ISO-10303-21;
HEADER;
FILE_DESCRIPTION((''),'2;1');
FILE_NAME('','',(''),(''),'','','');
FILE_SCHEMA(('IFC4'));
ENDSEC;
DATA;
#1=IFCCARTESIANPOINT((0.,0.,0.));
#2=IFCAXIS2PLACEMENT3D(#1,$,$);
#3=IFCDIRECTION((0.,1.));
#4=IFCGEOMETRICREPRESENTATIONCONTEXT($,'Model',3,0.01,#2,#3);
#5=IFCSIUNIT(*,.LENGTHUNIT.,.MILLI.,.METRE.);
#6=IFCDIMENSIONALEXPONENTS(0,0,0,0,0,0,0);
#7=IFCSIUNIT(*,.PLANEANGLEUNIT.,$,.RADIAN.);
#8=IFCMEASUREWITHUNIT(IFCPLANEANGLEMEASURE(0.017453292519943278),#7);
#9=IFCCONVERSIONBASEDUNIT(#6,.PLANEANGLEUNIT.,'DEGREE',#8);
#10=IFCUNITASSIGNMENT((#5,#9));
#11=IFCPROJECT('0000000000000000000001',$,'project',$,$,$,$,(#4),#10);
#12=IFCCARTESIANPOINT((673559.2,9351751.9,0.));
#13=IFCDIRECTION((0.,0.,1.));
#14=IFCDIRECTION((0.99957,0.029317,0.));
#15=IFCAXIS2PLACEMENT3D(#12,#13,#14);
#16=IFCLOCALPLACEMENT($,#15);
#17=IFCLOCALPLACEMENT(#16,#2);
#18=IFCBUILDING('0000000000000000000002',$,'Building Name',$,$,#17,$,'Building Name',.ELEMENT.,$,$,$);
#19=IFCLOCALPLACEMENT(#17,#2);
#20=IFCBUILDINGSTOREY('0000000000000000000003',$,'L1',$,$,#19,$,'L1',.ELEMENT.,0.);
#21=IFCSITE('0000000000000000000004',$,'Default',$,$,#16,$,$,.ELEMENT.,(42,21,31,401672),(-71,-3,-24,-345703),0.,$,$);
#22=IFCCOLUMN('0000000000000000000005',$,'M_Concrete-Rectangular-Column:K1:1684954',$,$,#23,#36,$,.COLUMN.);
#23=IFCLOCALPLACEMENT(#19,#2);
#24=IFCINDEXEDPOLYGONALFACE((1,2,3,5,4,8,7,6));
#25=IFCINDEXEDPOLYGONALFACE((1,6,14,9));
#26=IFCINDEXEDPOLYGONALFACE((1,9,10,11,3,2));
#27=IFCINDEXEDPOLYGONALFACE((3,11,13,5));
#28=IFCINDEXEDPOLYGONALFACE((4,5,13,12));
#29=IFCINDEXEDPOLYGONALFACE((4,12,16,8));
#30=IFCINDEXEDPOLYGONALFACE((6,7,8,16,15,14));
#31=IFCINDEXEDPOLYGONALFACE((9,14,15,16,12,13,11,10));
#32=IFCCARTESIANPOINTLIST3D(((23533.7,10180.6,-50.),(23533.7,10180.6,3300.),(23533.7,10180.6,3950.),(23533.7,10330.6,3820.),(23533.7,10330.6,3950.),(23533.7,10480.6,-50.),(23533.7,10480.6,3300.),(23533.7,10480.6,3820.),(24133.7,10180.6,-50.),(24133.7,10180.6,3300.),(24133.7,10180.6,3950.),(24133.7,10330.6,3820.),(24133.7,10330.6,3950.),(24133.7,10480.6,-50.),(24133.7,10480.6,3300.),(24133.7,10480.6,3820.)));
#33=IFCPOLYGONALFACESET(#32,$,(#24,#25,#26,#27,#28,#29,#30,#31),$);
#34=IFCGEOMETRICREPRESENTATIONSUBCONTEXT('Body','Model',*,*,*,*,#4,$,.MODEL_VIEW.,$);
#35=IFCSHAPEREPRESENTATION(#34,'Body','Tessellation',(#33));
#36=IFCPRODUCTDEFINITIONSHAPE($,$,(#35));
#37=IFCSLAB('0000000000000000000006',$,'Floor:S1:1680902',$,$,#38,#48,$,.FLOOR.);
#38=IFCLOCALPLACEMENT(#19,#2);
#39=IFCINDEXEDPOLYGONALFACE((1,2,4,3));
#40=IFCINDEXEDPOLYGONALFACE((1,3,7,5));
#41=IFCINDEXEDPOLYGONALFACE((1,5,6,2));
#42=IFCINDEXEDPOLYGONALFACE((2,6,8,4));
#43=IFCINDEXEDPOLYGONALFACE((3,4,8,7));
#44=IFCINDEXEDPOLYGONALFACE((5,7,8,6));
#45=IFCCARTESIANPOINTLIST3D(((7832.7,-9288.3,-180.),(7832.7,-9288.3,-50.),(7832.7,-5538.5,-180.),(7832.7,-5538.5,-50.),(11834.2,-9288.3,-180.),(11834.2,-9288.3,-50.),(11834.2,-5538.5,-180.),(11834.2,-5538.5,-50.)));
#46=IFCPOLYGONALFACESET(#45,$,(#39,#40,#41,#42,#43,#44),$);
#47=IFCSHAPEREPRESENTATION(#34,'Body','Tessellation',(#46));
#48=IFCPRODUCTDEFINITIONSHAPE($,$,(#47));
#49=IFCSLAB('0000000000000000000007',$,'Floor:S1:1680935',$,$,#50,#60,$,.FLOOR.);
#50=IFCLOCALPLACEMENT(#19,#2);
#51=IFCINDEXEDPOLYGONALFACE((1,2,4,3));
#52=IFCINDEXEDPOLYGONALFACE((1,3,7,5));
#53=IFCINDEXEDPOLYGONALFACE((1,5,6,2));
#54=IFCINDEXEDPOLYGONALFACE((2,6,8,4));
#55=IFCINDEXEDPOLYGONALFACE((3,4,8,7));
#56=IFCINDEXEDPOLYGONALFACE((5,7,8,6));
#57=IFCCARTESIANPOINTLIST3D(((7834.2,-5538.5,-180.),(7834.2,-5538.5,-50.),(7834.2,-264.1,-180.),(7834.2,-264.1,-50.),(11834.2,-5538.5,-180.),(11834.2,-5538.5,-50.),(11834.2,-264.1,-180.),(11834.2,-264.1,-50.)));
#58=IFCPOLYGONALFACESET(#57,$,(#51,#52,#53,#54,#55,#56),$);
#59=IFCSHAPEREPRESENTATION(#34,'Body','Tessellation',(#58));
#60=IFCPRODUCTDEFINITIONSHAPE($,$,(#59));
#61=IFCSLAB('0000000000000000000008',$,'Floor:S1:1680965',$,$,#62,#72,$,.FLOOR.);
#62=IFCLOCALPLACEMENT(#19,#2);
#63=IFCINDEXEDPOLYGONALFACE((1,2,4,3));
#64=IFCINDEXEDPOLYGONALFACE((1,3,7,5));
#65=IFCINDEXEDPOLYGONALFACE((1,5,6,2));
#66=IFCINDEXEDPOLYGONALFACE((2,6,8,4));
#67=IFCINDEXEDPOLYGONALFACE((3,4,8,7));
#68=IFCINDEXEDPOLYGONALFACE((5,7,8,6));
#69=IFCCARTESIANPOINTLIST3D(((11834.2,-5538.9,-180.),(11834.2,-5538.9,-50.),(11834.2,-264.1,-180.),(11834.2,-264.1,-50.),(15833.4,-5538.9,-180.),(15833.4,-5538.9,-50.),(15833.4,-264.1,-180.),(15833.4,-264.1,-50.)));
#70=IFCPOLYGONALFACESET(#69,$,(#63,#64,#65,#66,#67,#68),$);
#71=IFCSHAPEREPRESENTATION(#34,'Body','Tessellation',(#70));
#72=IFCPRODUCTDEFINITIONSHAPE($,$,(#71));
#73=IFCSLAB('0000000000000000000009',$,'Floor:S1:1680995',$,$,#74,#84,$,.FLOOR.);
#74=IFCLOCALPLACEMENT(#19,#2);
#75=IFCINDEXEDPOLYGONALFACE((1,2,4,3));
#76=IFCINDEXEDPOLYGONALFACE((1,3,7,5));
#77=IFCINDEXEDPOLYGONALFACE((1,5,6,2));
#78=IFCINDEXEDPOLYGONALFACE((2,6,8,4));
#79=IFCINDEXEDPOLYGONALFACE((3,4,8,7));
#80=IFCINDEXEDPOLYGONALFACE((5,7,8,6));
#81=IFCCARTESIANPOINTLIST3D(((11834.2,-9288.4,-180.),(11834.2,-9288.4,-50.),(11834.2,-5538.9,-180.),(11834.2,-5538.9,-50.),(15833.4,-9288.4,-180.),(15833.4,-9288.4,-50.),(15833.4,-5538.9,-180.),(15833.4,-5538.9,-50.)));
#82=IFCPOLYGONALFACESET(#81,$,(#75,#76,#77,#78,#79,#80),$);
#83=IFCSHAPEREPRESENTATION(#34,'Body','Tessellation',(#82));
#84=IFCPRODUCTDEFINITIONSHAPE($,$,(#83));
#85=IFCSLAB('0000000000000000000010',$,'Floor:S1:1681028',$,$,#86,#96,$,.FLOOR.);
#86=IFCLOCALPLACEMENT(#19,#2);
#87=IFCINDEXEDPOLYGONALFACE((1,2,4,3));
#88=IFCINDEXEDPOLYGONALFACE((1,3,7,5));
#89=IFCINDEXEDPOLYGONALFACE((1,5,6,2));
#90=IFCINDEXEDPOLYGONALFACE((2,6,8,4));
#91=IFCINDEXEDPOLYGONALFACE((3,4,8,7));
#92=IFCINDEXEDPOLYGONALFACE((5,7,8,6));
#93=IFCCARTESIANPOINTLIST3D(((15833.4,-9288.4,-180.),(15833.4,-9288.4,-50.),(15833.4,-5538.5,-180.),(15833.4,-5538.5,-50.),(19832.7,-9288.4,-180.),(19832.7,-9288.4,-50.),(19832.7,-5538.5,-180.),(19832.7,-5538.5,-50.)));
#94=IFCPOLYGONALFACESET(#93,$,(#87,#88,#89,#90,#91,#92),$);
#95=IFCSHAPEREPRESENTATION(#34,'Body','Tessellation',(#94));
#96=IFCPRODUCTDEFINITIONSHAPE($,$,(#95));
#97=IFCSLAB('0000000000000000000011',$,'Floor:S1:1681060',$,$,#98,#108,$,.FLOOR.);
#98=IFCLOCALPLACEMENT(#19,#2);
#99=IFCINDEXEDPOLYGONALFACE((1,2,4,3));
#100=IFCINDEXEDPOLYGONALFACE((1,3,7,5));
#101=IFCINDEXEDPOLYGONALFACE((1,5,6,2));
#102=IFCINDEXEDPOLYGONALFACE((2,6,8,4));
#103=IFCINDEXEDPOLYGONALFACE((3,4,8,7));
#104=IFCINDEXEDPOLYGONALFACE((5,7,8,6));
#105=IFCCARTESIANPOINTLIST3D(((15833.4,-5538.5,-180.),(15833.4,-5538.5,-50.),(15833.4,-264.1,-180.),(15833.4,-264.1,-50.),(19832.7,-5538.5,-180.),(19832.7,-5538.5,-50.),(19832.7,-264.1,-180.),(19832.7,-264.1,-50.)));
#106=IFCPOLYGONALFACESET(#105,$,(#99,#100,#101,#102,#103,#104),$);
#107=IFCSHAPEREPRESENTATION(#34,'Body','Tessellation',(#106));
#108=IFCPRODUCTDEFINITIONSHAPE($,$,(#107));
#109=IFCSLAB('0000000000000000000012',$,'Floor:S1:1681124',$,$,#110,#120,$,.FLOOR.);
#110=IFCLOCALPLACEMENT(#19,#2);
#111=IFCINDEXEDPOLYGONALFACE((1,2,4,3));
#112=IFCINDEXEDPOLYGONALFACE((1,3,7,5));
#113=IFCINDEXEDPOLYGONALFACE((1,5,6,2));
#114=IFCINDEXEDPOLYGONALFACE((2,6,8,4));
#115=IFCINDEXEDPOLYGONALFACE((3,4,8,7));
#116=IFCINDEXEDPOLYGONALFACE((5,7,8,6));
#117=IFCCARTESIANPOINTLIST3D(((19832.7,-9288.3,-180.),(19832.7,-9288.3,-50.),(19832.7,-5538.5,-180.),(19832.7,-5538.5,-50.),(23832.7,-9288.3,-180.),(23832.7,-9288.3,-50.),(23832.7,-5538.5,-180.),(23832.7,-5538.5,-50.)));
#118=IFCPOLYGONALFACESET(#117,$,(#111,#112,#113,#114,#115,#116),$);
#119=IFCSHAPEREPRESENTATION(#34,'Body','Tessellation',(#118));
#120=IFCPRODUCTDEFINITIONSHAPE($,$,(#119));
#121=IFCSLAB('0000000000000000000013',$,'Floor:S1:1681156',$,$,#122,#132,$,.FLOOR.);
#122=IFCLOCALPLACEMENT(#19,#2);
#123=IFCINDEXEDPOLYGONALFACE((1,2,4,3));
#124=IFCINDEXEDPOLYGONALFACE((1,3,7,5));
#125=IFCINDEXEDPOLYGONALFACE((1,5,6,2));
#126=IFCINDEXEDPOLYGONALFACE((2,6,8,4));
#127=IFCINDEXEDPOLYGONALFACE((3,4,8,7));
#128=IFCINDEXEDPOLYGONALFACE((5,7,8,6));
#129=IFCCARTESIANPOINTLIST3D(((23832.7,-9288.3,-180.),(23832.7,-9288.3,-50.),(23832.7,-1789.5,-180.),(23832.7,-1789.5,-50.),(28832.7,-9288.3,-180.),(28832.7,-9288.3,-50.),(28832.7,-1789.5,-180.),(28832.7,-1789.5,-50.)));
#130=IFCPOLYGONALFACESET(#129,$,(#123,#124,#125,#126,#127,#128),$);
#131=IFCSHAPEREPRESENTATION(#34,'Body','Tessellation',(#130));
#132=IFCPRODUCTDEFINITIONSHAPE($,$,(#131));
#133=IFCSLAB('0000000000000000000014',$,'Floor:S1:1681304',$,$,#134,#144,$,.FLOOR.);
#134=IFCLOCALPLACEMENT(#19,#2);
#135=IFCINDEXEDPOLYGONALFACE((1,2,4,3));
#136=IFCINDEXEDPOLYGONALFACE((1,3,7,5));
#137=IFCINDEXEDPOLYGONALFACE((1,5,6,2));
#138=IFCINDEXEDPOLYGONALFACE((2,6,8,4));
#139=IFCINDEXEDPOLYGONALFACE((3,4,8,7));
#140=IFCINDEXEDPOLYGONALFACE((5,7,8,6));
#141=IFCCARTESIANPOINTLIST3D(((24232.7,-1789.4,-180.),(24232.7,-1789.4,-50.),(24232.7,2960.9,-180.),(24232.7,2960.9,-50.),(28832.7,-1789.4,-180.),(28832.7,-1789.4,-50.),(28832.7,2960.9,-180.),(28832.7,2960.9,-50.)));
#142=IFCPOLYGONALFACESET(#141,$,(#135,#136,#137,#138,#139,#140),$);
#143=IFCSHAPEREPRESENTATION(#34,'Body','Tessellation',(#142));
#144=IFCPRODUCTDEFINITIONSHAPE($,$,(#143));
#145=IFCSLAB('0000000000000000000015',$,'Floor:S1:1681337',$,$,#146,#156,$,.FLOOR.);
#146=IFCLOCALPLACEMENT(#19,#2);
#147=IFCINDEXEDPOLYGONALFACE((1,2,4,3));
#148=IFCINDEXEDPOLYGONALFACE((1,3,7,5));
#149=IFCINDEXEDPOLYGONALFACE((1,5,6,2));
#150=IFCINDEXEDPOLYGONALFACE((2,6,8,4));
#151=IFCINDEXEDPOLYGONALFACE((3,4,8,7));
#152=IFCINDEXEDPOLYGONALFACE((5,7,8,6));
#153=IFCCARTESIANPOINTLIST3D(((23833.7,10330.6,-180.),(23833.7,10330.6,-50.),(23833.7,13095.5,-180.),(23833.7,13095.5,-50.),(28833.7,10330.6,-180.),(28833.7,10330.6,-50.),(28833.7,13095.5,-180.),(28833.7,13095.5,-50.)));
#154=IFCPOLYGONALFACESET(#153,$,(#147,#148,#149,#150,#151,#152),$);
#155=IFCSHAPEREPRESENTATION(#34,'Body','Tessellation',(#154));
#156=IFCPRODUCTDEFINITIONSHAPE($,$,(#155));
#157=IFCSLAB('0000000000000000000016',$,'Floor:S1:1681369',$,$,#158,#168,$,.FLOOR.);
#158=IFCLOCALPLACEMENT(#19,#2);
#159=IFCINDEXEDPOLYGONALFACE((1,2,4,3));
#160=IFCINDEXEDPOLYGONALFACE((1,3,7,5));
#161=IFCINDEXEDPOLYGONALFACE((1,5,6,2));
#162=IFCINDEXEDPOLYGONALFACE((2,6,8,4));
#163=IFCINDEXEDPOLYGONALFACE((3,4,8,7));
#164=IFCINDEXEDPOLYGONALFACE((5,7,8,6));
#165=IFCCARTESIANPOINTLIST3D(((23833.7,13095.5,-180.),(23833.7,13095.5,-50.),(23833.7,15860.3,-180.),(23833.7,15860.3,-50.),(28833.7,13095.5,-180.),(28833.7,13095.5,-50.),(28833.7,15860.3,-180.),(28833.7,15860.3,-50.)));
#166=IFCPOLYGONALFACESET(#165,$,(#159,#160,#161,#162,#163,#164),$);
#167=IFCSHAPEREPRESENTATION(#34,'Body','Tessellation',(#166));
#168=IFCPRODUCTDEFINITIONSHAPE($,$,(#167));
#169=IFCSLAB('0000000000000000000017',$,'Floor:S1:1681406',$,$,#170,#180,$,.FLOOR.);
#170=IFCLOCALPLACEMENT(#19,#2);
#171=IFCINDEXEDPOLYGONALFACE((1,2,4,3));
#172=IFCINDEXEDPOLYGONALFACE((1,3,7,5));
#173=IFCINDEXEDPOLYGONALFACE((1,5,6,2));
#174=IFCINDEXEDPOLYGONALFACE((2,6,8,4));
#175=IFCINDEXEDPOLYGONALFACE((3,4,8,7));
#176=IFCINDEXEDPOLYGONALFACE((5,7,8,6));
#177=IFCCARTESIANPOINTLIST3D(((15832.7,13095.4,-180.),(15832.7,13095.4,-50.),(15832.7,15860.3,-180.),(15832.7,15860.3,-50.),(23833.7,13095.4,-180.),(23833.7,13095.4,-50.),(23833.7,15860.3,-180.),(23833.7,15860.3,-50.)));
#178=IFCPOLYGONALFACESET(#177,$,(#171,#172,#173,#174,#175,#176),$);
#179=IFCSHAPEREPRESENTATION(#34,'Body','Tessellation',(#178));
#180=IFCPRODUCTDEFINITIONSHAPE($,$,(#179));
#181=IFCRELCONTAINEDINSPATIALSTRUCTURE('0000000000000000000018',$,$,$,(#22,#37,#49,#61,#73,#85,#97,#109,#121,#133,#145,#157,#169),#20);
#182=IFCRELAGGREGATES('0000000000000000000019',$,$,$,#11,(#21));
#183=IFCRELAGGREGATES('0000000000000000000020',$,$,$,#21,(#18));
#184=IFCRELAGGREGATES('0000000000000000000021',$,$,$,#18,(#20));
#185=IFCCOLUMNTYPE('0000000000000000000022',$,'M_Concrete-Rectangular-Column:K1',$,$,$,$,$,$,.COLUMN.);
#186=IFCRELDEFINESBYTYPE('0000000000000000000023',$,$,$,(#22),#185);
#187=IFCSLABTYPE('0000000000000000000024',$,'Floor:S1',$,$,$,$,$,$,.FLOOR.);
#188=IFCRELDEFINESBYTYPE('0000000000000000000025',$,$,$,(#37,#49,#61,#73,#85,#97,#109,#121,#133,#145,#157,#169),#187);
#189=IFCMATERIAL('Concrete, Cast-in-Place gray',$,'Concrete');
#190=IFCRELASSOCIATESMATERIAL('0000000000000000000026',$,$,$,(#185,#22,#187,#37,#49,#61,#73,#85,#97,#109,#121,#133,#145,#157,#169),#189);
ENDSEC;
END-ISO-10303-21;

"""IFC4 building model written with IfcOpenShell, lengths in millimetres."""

from ifc_helpers import new_model, entity, si_unit, converted_unit, direction, frame, origin, place, context, subcontext, project, spatial, indexed_curve, outline, extrude, source, transform, mapped, material, type_object, type_shapes, element, save


model = new_model("IFC4")

# Units and contexts
model_context = context("Model", 3, precision=0.01, world=origin(), true_north=direction((0.0, 1.0)))
body_context = subcontext(model_context, "Body", "Model", "MODEL_VIEW")
ifc_project = project(units=[si_unit("LENGTHUNIT", "METRE", prefix="MILLI"), converted_unit("PLANEANGLEUNIT", "DEGREE", entity("IfcPlaneAngleMeasure", 0.017453292519943278), si_unit("PLANEANGLEUNIT", "RADIAN"), dimensions=[0, 0, 0, 0, 0, 0, 0])], contexts=[model_context])

# Site, building, storey
site_placement = place(None, frame((673559.2, 9351751.9, 0.0), z_axis=(0.0, 0.0, 1.0), x_axis=(0.99957, 0.029317, 0.0)))
site = spatial("IfcSite", under=ifc_project, at=site_placement, Name="Default", CompositionType="ELEMENT", RefLatitude=(42, 21, 31, 401672), RefLongitude=(-71, -3, -24, -345703), RefElevation=0.0)
building_placement = place(site_placement, origin())
building = spatial("IfcBuilding", under=site, at=building_placement, Name="Building Name", LongName="Building Name", CompositionType="ELEMENT")
storey_placement = place(building_placement, origin())
storey = spatial("IfcBuildingStorey", under=building, at=storey_placement, Name="L1", LongName="L1", CompositionType="ELEMENT", Elevation=0.0)

# Column
ifc_material_1 = material(Name="Concrete, Cast-in-Place gray", Category="Concrete")
column_type = type_object("IfcColumnType", Name="M_Concrete-Rectangular-Column:K1", PredefinedType="COLUMN", material=ifc_material_1)
shared_shape = source(origin(), body_context, "Body", "SweptSolid", [
    extrude(outline(indexed_curve([(-2805.0, -150.0), (545.0, -150.0), (1065.0, -150.0), (1065.0, 0.0), (1195.0, 0.0), (1195.0, 150.0), (545.0, 150.0), (-2805.0, 150.0), (-2805.0, -150.0)], self_intersect=False)), frame((23533.7, 10330.6, 2755.0), z_axis=(1.0, 0.0, 0.0), x_axis=(0.0, 0.0, 1.0)), (0.0, 0.0, 1.0), 600.0),
])
type_shapes(column_type, [shared_shape])
column_placement = place(storey_placement, origin())
element("IfcColumn", 1, at=column_placement, inside=storey, type_object=column_type, material=ifc_material_1, Name="M_Concrete-Rectangular-Column:K1:1684954", PredefinedType="COLUMN", context=body_context, shape_type="MappedRepresentation", body=[
    mapped(shared_shape, transform((0.0, 0.0, 0.0), scale=1.0)),
])

# Slabs
slab_type_1 = type_object("IfcSlabType", Name="Floor:S1", PredefinedType="FLOOR", material=ifc_material_1)
slab_1_placement = place(storey_placement, origin())
element("IfcSlab", 2, at=slab_1_placement, inside=storey, type_object=slab_type_1, material=ifc_material_1, Name="Floor:S1:1680902", PredefinedType="FLOOR", context=body_context, shape_type="SweptSolid", body=[
    extrude(outline(indexed_curve([(-1874.9, -2000.7), (1874.9, -2000.7), (1874.9, 2000.7), (-1874.9, 2000.7), (-1874.9, -2000.7)], self_intersect=False)), frame((9833.4, -7413.4, -50.0), z_axis=(0.0, 0.0, -1.0), x_axis=(0.0, 1.0, 0.0)), (0.0, 0.0, 1.0), 130.0),
])
slab_2_placement = place(storey_placement, origin())
element("IfcSlab", 3, at=slab_2_placement, inside=storey, type_object=slab_type_1, material=ifc_material_1, Name="Floor:S1:1680935", PredefinedType="FLOOR", context=body_context, shape_type="SweptSolid", body=[
    extrude(outline(indexed_curve([(-2637.2, -2000.0), (2637.2, -2000.0), (2637.2, 2000.0), (-2637.2, 2000.0), (-2637.2, -2000.0)], self_intersect=False)), frame((9834.2, -2901.3, -50.0), z_axis=(0.0, 0.0, -1.0), x_axis=(0.0, 1.0, 0.0)), (0.0, 0.0, 1.0), 130.0),
])
slab_3_placement = place(storey_placement, origin())
element("IfcSlab", 4, at=slab_3_placement, inside=storey, type_object=slab_type_1, material=ifc_material_1, Name="Floor:S1:1680965", PredefinedType="FLOOR", context=body_context, shape_type="SweptSolid", body=[
    extrude(outline(indexed_curve([(-2637.4, -1999.6), (2637.4, -1999.6), (2637.4, 1999.6), (-2637.4, 1999.6), (-2637.4, -1999.6)], self_intersect=False)), frame((13833.8, -2901.5, -50.0), z_axis=(0.0, 0.0, -1.0), x_axis=(0.0, 1.0, 0.0)), (0.0, 0.0, 1.0), 130.0),
])
slab_4_placement = place(storey_placement, origin())
element("IfcSlab", 5, at=slab_4_placement, inside=storey, type_object=slab_type_1, material=ifc_material_1, Name="Floor:S1:1680995", PredefinedType="FLOOR", context=body_context, shape_type="SweptSolid", body=[
    extrude(outline(indexed_curve([(-1874.7, -1999.6), (1874.7, -1999.6), (1874.7, 1999.6), (-1874.7, 1999.6), (-1874.7, -1999.6)], self_intersect=False)), frame((13833.8, -7413.6, -50.0), z_axis=(0.0, 0.0, -1.0), x_axis=(0.0, 1.0, 0.0)), (0.0, 0.0, 1.0), 130.0),
])
slab_5_placement = place(storey_placement, origin())
element("IfcSlab", 6, at=slab_5_placement, inside=storey, type_object=slab_type_1, material=ifc_material_1, Name="Floor:S1:1681028", PredefinedType="FLOOR", context=body_context, shape_type="SweptSolid", body=[
    extrude(outline(indexed_curve([(-1874.9, -1999.6), (1874.9, -1999.6), (1874.9, 1999.6), (-1874.9, 1999.6), (-1874.9, -1999.6)], self_intersect=False)), frame((17833.0, -7413.5, -50.0), z_axis=(0.0, 0.0, -1.0), x_axis=(0.0, 1.0, 0.0)), (0.0, 0.0, 1.0), 130.0),
])
slab_6_placement = place(storey_placement, origin())
element("IfcSlab", 7, at=slab_6_placement, inside=storey, type_object=slab_type_1, material=ifc_material_1, Name="Floor:S1:1681060", PredefinedType="FLOOR", context=body_context, shape_type="SweptSolid", body=[
    extrude(outline(indexed_curve([(-2637.2, -1999.6), (2637.2, -1999.6), (2637.2, 1999.6), (-2637.2, 1999.6), (-2637.2, -1999.6)], self_intersect=False)), frame((17833.0, -2901.3, -50.0), z_axis=(0.0, 0.0, -1.0), x_axis=(0.0, 1.0, 0.0)), (0.0, 0.0, 1.0), 130.0),
])
slab_7_placement = place(storey_placement, origin())
element("IfcSlab", 8, at=slab_7_placement, inside=storey, type_object=slab_type_1, material=ifc_material_1, Name="Floor:S1:1681124", PredefinedType="FLOOR", context=body_context, shape_type="SweptSolid", body=[
    extrude(outline(indexed_curve([(-1874.9, -2000.0), (1874.9, -2000.0), (1874.9, 2000.0), (-1874.9, 2000.0), (-1874.9, -2000.0)], self_intersect=False)), frame((21832.7, -7413.4, -50.0), z_axis=(0.0, 0.0, -1.0), x_axis=(0.0, 1.0, 0.0)), (0.0, 0.0, 1.0), 130.0),
])
slab_8_placement = place(storey_placement, origin())
element("IfcSlab", 9, at=slab_8_placement, inside=storey, type_object=slab_type_1, material=ifc_material_1, Name="Floor:S1:1681156", PredefinedType="FLOOR", context=body_context, shape_type="SweptSolid", body=[
    extrude(outline(indexed_curve([(-3749.4, -2500.0), (3749.4, -2500.0), (3749.4, 2500.0), (-3749.4, 2500.0), (-3749.4, -2500.0)], self_intersect=False)), frame((26332.7, -5538.9, -50.0), z_axis=(0.0, 0.0, -1.0), x_axis=(0.0, 1.0, 0.0)), (0.0, 0.0, 1.0), 130.0),
])
slab_9_placement = place(storey_placement, origin())
element("IfcSlab", 10, at=slab_9_placement, inside=storey, type_object=slab_type_1, material=ifc_material_1, Name="Floor:S1:1681304", PredefinedType="FLOOR", context=body_context, shape_type="SweptSolid", body=[
    extrude(outline(indexed_curve([(-2375.2, -2300.0), (2375.2, -2300.0), (2375.2, 2300.0), (-2375.2, 2300.0), (-2375.2, -2300.0)], self_intersect=False)), frame((26532.7, 585.8, -50.0), z_axis=(0.0, 0.0, -1.0), x_axis=(0.0, 1.0, 0.0)), (0.0, 0.0, 1.0), 130.0),
])
slab_10_placement = place(storey_placement, origin())
element("IfcSlab", 11, at=slab_10_placement, inside=storey, type_object=slab_type_1, material=ifc_material_1, Name="Floor:S1:1681337", PredefinedType="FLOOR", context=body_context, shape_type="SweptSolid", body=[
    extrude(outline(indexed_curve([(-1382.4, -2500.0), (1382.4, -2500.0), (1382.4, 2500.0), (-1382.4, 2500.0), (-1382.4, -2500.0)], self_intersect=False)), frame((26333.7, 11713.0, -50.0), z_axis=(0.0, 0.0, -1.0), x_axis=(0.0, 1.0, 0.0)), (0.0, 0.0, 1.0), 130.0),
])
slab_11_placement = place(storey_placement, origin())
element("IfcSlab", 12, at=slab_11_placement, inside=storey, type_object=slab_type_1, material=ifc_material_1, Name="Floor:S1:1681369", PredefinedType="FLOOR", context=body_context, shape_type="SweptSolid", body=[
    extrude(outline(indexed_curve([(-1382.4, -2500.0), (1382.4, -2500.0), (1382.4, 2500.0), (-1382.4, 2500.0), (-1382.4, -2500.0)], self_intersect=False)), frame((26333.7, 14477.9, -50.0), z_axis=(0.0, 0.0, -1.0), x_axis=(0.0, 1.0, 0.0)), (0.0, 0.0, 1.0), 130.0),
])
slab_12_placement = place(storey_placement, origin())
element("IfcSlab", 13, at=slab_12_placement, inside=storey, type_object=slab_type_1, material=ifc_material_1, Name="Floor:S1:1681406", PredefinedType="FLOOR", context=body_context, shape_type="SweptSolid", body=[
    extrude(outline(indexed_curve([(-1382.4, -4000.5), (1382.4, -4000.5), (1382.4, 4000.5), (-1382.4, 4000.5), (-1382.4, -4000.5)], self_intersect=False)), frame((19833.2, 14477.9, -50.0), z_axis=(0.0, 0.0, -1.0), x_axis=(0.0, 1.0, 0.0)), (0.0, 0.0, 1.0), 130.0),
])

save(model, "model.ifc")
